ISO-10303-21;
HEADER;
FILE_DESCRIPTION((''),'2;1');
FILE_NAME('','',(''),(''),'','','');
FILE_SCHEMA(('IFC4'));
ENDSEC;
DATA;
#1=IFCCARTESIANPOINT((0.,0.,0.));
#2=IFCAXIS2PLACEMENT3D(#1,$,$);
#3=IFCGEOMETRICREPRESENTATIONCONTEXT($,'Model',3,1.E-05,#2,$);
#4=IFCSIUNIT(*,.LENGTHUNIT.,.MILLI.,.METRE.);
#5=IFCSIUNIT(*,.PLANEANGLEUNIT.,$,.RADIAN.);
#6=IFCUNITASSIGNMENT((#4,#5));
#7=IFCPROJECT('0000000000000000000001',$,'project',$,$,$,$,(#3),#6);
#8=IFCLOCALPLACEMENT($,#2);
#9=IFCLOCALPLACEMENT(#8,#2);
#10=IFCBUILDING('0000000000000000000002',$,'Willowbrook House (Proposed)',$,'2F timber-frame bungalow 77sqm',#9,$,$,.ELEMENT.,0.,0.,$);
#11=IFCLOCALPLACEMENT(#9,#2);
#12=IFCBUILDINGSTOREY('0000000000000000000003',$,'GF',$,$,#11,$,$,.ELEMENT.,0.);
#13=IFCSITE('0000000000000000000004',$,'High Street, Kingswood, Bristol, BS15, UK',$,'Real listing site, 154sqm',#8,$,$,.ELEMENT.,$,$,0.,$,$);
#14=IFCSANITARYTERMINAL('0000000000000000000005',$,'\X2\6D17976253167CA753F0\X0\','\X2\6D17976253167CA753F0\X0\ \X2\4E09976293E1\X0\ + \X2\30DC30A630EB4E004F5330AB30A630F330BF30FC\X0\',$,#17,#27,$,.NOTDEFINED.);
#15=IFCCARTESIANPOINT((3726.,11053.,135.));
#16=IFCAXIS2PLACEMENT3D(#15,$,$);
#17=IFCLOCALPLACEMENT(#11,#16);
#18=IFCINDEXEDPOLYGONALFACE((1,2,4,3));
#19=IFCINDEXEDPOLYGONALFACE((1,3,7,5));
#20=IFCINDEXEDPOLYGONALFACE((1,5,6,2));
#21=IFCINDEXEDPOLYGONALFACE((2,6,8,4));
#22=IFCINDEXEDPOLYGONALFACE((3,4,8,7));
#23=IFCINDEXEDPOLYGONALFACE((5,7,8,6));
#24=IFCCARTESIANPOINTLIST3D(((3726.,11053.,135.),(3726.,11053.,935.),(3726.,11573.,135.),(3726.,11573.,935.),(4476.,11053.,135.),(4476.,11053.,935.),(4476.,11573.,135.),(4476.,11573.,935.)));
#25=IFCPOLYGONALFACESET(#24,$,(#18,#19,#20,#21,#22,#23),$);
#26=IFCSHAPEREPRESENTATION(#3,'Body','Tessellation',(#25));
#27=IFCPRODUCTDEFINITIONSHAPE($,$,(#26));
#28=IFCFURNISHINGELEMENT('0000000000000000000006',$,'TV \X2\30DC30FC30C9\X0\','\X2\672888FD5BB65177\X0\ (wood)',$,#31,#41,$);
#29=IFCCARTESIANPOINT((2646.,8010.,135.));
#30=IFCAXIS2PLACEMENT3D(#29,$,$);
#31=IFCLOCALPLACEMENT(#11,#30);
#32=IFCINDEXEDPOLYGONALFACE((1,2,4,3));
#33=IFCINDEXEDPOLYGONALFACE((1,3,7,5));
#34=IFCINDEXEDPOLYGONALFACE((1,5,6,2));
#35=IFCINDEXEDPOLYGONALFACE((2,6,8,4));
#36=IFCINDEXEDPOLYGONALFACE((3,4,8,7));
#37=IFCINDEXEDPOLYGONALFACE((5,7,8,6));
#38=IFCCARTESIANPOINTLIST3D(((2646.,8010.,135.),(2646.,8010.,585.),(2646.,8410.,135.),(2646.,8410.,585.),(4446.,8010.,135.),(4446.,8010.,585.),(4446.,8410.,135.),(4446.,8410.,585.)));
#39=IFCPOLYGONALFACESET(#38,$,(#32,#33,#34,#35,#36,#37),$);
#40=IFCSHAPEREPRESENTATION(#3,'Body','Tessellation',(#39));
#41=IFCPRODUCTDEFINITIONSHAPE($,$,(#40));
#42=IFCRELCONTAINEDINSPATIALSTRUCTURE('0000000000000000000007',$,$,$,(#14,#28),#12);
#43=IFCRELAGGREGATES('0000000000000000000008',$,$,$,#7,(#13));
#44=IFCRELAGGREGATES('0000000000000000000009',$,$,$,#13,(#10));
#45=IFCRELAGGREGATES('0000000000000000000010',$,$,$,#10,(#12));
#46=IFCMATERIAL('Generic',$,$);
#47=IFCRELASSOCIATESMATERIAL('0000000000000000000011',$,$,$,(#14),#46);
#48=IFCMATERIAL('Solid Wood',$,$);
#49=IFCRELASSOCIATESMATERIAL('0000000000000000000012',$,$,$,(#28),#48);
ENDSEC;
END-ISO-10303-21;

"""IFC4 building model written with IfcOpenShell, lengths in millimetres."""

from ifc_helpers import new_model, si_unit, frame, frame_2d, origin, place, context, project, spatial, rectangle, extrude, material, element, save


model = new_model("IFC4")

# Units and contexts
model_context = context("Model", 3, precision=1e-05, world=origin())
ifc_project = project(units=[si_unit("LENGTHUNIT", "METRE", prefix="MILLI"), si_unit("PLANEANGLEUNIT", "RADIAN")], contexts=[model_context])

# Site, building, storey
site_placement = place(None, origin())
site = spatial("IfcSite", under=ifc_project, at=site_placement, Name="High Street, Kingswood, Bristol, BS15, UK", ObjectType="Real listing site, 154sqm", CompositionType="ELEMENT", RefElevation=0.0)
building_placement = place(site_placement, origin())
building = spatial("IfcBuilding", under=site, at=building_placement, Name="Willowbrook House (Proposed)", ObjectType="2F timber-frame bungalow 77sqm", CompositionType="ELEMENT", ElevationOfRefHeight=0.0, ElevationOfTerrain=0.0)
storey_placement = place(building_placement, origin())
storey = spatial("IfcBuildingStorey", under=building, at=storey_placement, Name="GF", CompositionType="ELEMENT", Elevation=0.0)

# Shared definitions
ifc_material_1 = material(Name="Solid Wood")

# Shared definitions
ifc_material_2 = material(Name="Generic")

# Sanitary terminal
sanitary_terminal_1_placement = place(storey_placement, frame((3726.0, 11053.0, 135.0)))
element("IfcSanitaryTerminal", 1, at=sanitary_terminal_1_placement, inside=storey, material=ifc_material_2, Name="洗面化粧台", Description="洗面化粧台 三面鏡 + ボウル一体カウンター", PredefinedType="NOTDEFINED", context=model_context, shape_type="SweptSolid", body=[
    extrude(rectangle(XDim=750.0, YDim=520.0, at=frame_2d((375.0, 260.0))), frame((3726.0, 11053.0, 135.0)), (0.0, 0.0, 1.0), 800.0),
])

# Furnishing element
furnishing_placement = place(storey_placement, frame((2646.0, 8010.0, 135.0)))
element("IfcFurnishingElement", 2, at=furnishing_placement, inside=storey, material=ifc_material_1, Name="TV ボード", Description="木製家具 (wood)", context=model_context, shape_type="SweptSolid", body=[
    extrude(rectangle(XDim=1800.0, YDim=400.0, at=frame_2d((900.0, 200.0))), frame((2646.0, 8010.0, 135.0)), (0.0, 0.0, 1.0), 450.0),
])

save(model, "model.ifc")
